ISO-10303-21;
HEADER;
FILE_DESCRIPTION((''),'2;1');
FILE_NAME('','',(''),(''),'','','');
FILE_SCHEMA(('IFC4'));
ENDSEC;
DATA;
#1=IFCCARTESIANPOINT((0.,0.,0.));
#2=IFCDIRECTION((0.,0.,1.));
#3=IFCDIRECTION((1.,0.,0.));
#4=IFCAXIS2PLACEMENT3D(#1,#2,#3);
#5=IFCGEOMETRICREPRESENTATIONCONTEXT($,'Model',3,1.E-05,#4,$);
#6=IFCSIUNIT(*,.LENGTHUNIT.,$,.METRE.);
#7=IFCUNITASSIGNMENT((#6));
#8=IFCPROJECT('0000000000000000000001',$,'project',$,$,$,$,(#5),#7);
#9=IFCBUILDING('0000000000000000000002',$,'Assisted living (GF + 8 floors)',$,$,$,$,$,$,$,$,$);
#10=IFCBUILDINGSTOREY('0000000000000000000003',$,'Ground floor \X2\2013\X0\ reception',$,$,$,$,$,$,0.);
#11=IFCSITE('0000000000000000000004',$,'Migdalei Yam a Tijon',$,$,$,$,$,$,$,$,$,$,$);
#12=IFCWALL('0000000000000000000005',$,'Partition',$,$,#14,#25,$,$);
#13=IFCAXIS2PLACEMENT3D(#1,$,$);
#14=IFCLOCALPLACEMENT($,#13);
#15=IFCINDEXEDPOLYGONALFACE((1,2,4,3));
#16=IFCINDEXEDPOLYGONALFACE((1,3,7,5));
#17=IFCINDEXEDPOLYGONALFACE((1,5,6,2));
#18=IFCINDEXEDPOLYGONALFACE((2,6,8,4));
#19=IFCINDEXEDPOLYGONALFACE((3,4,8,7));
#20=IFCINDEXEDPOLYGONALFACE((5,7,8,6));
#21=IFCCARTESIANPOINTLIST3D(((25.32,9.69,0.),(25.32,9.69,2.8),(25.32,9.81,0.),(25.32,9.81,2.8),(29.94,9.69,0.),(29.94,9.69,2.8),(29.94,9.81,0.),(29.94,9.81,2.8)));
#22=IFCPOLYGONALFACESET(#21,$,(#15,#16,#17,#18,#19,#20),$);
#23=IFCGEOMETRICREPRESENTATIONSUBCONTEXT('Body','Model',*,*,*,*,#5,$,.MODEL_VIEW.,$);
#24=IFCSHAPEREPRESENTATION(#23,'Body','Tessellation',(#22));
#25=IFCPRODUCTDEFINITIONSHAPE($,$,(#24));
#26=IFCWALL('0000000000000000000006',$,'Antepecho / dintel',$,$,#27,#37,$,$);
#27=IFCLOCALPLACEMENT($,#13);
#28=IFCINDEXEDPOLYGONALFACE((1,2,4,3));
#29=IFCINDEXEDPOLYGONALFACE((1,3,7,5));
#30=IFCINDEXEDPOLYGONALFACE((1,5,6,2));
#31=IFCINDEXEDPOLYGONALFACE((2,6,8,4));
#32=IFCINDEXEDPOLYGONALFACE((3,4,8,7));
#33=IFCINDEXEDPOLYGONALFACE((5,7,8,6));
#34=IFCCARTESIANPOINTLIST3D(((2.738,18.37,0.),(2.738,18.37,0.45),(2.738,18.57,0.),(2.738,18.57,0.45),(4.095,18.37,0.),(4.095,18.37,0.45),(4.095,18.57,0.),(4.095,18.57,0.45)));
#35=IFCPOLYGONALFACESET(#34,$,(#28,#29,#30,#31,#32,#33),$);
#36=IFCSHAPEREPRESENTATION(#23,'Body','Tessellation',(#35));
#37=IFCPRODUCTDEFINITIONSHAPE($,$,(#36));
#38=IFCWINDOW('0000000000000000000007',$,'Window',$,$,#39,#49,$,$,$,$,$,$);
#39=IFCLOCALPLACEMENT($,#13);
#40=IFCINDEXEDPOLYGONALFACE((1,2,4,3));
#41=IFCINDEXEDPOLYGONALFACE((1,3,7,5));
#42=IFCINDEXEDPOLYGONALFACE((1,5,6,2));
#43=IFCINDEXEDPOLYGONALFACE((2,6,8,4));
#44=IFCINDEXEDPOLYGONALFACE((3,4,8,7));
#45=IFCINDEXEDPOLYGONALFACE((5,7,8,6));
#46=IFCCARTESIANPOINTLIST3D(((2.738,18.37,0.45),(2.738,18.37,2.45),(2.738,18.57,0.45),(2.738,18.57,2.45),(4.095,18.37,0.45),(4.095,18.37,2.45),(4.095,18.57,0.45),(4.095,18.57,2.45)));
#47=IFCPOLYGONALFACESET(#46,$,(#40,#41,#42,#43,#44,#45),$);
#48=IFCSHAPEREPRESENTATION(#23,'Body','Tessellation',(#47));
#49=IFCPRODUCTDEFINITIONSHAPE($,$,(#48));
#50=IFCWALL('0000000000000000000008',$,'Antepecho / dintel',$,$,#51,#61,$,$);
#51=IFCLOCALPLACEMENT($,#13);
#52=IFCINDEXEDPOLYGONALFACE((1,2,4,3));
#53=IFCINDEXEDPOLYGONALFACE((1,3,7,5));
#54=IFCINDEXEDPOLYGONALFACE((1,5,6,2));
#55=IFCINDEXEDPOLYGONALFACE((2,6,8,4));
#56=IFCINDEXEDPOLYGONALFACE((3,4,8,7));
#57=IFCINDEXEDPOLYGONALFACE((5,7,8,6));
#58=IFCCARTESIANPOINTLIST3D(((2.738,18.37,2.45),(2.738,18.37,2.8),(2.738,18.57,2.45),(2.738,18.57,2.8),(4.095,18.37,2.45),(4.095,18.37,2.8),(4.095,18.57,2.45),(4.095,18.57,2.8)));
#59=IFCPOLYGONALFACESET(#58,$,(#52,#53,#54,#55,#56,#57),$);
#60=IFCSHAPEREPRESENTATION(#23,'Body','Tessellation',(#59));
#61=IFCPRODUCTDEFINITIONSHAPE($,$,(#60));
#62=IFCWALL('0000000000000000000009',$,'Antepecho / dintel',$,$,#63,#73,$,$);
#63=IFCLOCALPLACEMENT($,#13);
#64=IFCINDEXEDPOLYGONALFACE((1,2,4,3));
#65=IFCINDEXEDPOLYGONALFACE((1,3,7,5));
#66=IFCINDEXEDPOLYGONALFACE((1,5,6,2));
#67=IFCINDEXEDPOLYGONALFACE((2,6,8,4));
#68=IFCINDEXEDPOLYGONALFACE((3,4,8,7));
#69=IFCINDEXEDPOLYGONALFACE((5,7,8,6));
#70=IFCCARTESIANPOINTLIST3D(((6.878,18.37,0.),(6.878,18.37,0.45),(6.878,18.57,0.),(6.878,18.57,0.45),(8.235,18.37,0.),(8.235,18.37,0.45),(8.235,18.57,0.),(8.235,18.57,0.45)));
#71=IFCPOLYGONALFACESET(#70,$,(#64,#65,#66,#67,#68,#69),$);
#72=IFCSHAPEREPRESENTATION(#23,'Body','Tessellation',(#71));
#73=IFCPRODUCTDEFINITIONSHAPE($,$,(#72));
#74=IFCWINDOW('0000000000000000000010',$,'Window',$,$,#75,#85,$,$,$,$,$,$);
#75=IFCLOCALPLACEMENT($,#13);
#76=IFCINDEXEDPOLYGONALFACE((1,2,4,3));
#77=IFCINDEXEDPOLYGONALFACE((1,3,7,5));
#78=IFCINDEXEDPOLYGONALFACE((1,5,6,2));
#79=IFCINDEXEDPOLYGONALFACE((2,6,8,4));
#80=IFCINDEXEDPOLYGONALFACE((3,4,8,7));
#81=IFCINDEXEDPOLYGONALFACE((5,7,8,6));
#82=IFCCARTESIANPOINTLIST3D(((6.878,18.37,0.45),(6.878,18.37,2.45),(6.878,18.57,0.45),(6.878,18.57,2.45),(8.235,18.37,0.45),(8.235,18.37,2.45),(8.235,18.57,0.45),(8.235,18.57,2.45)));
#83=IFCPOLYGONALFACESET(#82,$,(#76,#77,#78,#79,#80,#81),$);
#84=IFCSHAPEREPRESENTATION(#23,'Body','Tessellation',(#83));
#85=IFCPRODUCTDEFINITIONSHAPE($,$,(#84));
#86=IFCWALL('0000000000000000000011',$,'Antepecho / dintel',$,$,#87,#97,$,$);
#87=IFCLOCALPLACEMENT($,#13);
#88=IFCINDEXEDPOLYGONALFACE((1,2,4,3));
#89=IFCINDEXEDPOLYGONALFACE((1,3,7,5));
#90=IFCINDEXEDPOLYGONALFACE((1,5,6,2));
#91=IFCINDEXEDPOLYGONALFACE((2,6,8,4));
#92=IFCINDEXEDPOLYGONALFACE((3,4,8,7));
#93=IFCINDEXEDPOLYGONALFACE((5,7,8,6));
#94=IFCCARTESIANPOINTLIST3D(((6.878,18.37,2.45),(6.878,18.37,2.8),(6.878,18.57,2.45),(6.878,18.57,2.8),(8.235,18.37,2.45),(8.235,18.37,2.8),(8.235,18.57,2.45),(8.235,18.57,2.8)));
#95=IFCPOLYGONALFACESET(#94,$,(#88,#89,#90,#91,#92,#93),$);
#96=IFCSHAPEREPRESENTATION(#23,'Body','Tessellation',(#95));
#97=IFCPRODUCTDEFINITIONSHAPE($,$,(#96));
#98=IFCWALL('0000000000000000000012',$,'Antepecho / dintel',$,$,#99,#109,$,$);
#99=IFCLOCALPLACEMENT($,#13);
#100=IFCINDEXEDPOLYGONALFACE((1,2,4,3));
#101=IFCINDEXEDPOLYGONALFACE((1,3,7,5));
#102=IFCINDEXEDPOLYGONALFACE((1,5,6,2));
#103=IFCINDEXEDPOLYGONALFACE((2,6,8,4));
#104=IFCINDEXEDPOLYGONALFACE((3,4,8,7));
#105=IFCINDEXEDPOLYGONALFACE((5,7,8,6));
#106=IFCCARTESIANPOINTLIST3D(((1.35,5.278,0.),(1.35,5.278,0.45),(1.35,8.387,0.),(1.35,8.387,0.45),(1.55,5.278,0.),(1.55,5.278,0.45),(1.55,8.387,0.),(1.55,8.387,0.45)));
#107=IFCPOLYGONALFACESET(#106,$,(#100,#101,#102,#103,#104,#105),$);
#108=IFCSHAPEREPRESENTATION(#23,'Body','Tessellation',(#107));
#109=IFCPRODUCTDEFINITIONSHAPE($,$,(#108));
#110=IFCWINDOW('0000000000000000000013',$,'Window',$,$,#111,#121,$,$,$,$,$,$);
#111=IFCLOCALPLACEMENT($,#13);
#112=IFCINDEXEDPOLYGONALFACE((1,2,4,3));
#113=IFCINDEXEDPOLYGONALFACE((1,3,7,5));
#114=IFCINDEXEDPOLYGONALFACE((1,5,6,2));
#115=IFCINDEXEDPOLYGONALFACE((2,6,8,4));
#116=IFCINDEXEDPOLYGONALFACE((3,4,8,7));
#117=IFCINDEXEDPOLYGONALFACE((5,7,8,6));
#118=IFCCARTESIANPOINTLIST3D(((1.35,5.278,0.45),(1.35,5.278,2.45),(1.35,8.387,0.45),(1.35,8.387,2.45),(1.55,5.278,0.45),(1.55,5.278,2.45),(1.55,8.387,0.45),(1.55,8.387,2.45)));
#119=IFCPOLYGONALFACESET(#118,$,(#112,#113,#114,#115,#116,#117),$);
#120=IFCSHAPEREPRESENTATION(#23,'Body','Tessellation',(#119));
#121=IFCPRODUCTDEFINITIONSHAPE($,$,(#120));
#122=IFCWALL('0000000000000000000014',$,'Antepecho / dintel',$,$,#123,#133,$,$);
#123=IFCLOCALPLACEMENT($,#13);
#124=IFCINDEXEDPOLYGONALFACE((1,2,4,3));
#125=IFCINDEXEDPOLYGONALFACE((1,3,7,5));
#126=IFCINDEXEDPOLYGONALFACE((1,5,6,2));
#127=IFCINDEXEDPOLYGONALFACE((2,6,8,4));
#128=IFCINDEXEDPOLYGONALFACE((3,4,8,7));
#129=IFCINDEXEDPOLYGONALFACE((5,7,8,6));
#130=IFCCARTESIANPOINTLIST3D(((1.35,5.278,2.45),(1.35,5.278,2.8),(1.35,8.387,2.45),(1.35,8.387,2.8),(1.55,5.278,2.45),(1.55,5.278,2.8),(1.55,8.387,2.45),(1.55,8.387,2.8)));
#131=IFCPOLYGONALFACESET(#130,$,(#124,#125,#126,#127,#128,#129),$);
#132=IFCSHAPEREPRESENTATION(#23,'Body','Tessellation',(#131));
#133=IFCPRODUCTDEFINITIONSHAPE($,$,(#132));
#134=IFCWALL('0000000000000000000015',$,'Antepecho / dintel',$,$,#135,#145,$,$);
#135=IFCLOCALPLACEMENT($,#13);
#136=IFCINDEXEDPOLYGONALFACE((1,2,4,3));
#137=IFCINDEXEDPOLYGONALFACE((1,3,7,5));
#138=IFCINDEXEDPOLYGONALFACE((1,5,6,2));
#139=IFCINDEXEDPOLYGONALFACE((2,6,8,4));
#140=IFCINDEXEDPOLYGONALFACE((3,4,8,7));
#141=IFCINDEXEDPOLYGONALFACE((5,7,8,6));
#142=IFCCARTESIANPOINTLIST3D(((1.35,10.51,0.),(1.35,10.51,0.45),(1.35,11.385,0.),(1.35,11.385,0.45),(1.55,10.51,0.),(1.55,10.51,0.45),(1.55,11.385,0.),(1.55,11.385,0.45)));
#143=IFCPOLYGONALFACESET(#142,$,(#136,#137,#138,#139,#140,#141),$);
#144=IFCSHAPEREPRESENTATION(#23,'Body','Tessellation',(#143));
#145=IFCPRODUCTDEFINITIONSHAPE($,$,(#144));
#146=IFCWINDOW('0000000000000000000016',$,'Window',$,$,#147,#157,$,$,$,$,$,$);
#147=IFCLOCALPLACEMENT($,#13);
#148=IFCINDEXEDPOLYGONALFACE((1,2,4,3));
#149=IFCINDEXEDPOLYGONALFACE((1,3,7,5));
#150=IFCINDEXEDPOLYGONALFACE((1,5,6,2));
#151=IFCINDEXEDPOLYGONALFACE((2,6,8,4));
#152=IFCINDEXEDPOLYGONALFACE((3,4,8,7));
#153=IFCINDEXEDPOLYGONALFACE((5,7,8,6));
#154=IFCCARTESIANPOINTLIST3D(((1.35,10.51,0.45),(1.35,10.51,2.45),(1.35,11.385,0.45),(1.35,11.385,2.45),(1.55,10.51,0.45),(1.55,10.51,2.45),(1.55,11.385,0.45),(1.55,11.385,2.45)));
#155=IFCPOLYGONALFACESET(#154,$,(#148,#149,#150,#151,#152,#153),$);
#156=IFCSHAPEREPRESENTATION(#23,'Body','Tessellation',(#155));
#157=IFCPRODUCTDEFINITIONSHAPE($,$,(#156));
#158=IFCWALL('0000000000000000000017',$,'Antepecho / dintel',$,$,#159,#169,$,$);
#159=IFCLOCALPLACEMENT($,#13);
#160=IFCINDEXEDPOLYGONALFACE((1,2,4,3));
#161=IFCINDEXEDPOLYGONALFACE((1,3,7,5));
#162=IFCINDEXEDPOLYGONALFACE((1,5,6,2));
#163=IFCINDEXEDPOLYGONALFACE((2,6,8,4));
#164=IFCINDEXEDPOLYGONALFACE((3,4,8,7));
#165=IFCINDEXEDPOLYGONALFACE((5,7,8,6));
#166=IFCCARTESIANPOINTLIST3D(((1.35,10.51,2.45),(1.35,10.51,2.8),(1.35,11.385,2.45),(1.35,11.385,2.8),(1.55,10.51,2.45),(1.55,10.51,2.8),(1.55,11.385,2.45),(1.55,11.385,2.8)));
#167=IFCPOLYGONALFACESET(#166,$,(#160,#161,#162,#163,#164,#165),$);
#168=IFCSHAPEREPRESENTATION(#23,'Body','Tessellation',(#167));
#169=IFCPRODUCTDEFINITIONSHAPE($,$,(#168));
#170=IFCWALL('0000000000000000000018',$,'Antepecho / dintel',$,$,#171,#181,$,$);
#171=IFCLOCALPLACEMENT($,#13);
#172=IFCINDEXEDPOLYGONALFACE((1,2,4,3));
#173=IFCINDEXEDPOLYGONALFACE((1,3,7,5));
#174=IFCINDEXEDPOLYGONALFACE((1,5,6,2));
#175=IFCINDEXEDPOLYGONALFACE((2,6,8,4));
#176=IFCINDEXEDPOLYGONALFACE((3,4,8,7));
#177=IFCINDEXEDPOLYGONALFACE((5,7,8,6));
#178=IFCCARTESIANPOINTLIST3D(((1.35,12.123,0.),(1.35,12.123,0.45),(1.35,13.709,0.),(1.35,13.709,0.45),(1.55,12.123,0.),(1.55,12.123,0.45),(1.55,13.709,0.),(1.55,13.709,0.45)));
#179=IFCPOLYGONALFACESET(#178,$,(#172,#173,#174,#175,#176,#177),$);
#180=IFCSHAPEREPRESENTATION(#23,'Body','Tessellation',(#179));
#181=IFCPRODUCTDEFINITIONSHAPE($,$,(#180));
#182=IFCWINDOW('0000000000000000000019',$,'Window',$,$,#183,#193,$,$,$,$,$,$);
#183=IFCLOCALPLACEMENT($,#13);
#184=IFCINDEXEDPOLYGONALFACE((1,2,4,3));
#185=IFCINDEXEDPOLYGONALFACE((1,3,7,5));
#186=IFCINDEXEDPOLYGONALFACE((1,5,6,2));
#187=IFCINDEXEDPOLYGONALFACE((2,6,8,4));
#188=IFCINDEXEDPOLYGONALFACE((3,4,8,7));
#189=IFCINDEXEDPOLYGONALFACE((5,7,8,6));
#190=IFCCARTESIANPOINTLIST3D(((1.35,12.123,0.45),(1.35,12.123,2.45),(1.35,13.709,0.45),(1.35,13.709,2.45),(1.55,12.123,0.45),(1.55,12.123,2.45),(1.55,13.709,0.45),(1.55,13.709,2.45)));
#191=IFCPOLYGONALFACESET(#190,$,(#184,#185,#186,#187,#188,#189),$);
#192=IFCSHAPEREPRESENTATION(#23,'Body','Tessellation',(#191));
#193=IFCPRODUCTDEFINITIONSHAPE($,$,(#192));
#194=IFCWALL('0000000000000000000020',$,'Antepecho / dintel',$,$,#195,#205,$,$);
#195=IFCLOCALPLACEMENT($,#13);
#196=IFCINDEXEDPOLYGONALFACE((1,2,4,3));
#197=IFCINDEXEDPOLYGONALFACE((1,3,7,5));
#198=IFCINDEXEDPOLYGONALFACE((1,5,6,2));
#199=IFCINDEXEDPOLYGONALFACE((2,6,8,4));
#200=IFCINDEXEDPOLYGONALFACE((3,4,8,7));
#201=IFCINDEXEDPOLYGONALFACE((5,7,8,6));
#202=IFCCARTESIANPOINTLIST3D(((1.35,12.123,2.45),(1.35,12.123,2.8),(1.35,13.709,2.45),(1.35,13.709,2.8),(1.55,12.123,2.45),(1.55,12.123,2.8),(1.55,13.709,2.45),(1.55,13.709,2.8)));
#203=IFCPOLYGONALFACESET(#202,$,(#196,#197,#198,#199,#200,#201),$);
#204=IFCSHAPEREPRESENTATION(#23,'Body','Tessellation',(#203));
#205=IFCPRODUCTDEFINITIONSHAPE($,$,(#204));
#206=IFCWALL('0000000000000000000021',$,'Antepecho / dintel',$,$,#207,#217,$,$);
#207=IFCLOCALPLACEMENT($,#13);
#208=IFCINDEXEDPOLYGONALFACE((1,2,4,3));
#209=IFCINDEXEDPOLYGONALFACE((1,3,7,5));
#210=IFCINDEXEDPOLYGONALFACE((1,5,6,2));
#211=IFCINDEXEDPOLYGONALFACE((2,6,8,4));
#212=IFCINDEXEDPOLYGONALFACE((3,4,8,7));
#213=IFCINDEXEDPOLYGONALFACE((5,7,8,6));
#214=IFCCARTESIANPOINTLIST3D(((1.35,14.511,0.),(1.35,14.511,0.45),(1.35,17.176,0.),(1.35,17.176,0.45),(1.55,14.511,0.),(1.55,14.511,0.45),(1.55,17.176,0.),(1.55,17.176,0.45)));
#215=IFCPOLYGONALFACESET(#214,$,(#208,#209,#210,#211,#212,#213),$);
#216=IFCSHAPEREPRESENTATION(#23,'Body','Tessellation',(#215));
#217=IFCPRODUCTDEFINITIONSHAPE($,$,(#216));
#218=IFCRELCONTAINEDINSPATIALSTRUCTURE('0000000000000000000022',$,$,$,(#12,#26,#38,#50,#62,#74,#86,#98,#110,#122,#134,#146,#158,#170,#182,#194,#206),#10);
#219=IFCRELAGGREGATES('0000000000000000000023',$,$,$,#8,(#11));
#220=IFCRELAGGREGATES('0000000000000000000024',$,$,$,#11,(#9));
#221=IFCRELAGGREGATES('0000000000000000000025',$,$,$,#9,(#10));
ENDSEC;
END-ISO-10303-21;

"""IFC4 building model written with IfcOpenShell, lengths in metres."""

from ifc_helpers import new_model, si_unit, frame, origin_with_axes, context, subcontext, project, spatial, line, indexed_curve, outline, extrude, element, save


model = new_model("IFC4")

# Units and contexts
model_context = context("Model", 3, precision=1e-05, world=origin_with_axes())
body_context = subcontext(model_context, "Body", "Model", "MODEL_VIEW")
ifc_project = project(units=[si_unit("LENGTHUNIT", "METRE")], contexts=[model_context])

# Site, building, storey
site = spatial("IfcSite", under=ifc_project, Name="Migdalei Yam a Tijon")
building = spatial("IfcBuilding", under=site, Name="Assisted living (GF + 8 floors)")
storey = spatial("IfcBuildingStorey", under=building, Name="Ground floor – reception", Elevation=0.0)

# Walls
element("IfcWall", 1, inside=storey, Name="Partition", context=body_context, shape_type="SweptSolid", body=[
    extrude(outline(indexed_curve([(0.0, 0.0), (4.62, 0.0), (4.62, 0.12), (0.0, 0.12)], segments=[line(1, 2, 3, 4, 1)])), frame((25.32, 9.69, 0.0), z_axis=(0.0, 0.0, 1.0), x_axis=(1.0, 0.0, 0.0)), (0.0, 0.0, 1.0), 2.8),
])
element("IfcWall", 2, inside=storey, Name="Antepecho / dintel", context=body_context, shape_type="SweptSolid", body=[
    extrude(outline(indexed_curve([(0.0, 0.0), (1.357, 0.0), (1.357, 0.2), (0.0, 0.2)], segments=[line(1, 2, 3, 4, 1)])), frame((2.738, 18.37, 0.0), z_axis=(0.0, 0.0, 1.0), x_axis=(1.0, 0.0, 0.0)), (0.0, 0.0, 1.0), 0.45),
])

# Window
element("IfcWindow", 3, inside=storey, Name="Window", context=body_context, shape_type="SweptSolid", body=[
    extrude(outline(indexed_curve([(0.0, 0.0), (1.357, 0.0), (1.357, 0.2), (0.0, 0.2)], segments=[line(1, 2, 3, 4, 1)])), frame((2.738, 18.37, 0.45), z_axis=(0.0, 0.0, 1.0), x_axis=(1.0, 0.0, 0.0)), (0.0, 0.0, 1.0), 2.0),
])

# Walls
element("IfcWall", 4, inside=storey, Name="Antepecho / dintel", context=body_context, shape_type="SweptSolid", body=[
    extrude(outline(indexed_curve([(0.0, 0.0), (1.357, 0.0), (1.357, 0.2), (0.0, 0.2)], segments=[line(1, 2, 3, 4, 1)])), frame((2.738, 18.37, 2.45), z_axis=(0.0, 0.0, 1.0), x_axis=(1.0, 0.0, 0.0)), (0.0, 0.0, 1.0), 0.35),
])
element("IfcWall", 5, inside=storey, Name="Antepecho / dintel", context=body_context, shape_type="SweptSolid", body=[
    extrude(outline(indexed_curve([(0.0, 0.0), (1.357, 0.0), (1.357, 0.2), (0.0, 0.2)], segments=[line(1, 2, 3, 4, 1)])), frame((6.878, 18.37, 0.0), z_axis=(0.0, 0.0, 1.0), x_axis=(1.0, 0.0, 0.0)), (0.0, 0.0, 1.0), 0.45),
])

# Window
element("IfcWindow", 6, inside=storey, Name="Window", context=body_context, shape_type="SweptSolid", body=[
    extrude(outline(indexed_curve([(0.0, 0.0), (1.357, 0.0), (1.357, 0.2), (0.0, 0.2)], segments=[line(1, 2, 3, 4, 1)])), frame((6.878, 18.37, 0.45), z_axis=(0.0, 0.0, 1.0), x_axis=(1.0, 0.0, 0.0)), (0.0, 0.0, 1.0), 2.0),
])

# Walls
element("IfcWall", 7, inside=storey, Name="Antepecho / dintel", context=body_context, shape_type="SweptSolid", body=[
    extrude(outline(indexed_curve([(0.0, 0.0), (1.357, 0.0), (1.357, 0.2), (0.0, 0.2)], segments=[line(1, 2, 3, 4, 1)])), frame((6.878, 18.37, 2.45), z_axis=(0.0, 0.0, 1.0), x_axis=(1.0, 0.0, 0.0)), (0.0, 0.0, 1.0), 0.35),
])
element("IfcWall", 8, inside=storey, Name="Antepecho / dintel", context=body_context, shape_type="SweptSolid", body=[
    extrude(outline(indexed_curve([(0.0, 0.0), (0.2, 0.0), (0.2, 3.109), (0.0, 3.109)], segments=[line(1, 2, 3, 4, 1)])), frame((1.35, 5.278, 0.0), z_axis=(0.0, 0.0, 1.0), x_axis=(1.0, 0.0, 0.0)), (0.0, 0.0, 1.0), 0.45),
])

# Window
element("IfcWindow", 9, inside=storey, Name="Window", context=body_context, shape_type="SweptSolid", body=[
    extrude(outline(indexed_curve([(0.0, 0.0), (0.2, 0.0), (0.2, 3.109), (0.0, 3.109)], segments=[line(1, 2, 3, 4, 1)])), frame((1.35, 5.278, 0.45), z_axis=(0.0, 0.0, 1.0), x_axis=(1.0, 0.0, 0.0)), (0.0, 0.0, 1.0), 2.0),
])

# Walls
element("IfcWall", 10, inside=storey, Name="Antepecho / dintel", context=body_context, shape_type="SweptSolid", body=[
    extrude(outline(indexed_curve([(0.0, 0.0), (0.2, 0.0), (0.2, 3.109), (0.0, 3.109)], segments=[line(1, 2, 3, 4, 1)])), frame((1.35, 5.278, 2.45), z_axis=(0.0, 0.0, 1.0), x_axis=(1.0, 0.0, 0.0)), (0.0, 0.0, 1.0), 0.35),
])
element("IfcWall", 11, inside=storey, Name="Antepecho / dintel", context=body_context, shape_type="SweptSolid", body=[
    extrude(outline(indexed_curve([(0.0, 0.0), (0.2, 0.0), (0.2, 0.875), (0.0, 0.875)], segments=[line(1, 2, 3, 4, 1)])), frame((1.35, 10.51, 0.0), z_axis=(0.0, 0.0, 1.0), x_axis=(1.0, 0.0, 0.0)), (0.0, 0.0, 1.0), 0.45),
])

# Window
element("IfcWindow", 12, inside=storey, Name="Window", context=body_context, shape_type="SweptSolid", body=[
    extrude(outline(indexed_curve([(0.0, 0.0), (0.2, 0.0), (0.2, 0.875), (0.0, 0.875)], segments=[line(1, 2, 3, 4, 1)])), frame((1.35, 10.51, 0.45), z_axis=(0.0, 0.0, 1.0), x_axis=(1.0, 0.0, 0.0)), (0.0, 0.0, 1.0), 2.0),
])

# Walls
element("IfcWall", 13, inside=storey, Name="Antepecho / dintel", context=body_context, shape_type="SweptSolid", body=[
    extrude(outline(indexed_curve([(0.0, 0.0), (0.2, 0.0), (0.2, 0.875), (0.0, 0.875)], segments=[line(1, 2, 3, 4, 1)])), frame((1.35, 10.51, 2.45), z_axis=(0.0, 0.0, 1.0), x_axis=(1.0, 0.0, 0.0)), (0.0, 0.0, 1.0), 0.35),
])
element("IfcWall", 14, inside=storey, Name="Antepecho / dintel", context=body_context, shape_type="SweptSolid", body=[
    extrude(outline(indexed_curve([(0.0, 0.0), (0.2, 0.0), (0.2, 1.586), (0.0, 1.586)], segments=[line(1, 2, 3, 4, 1)])), frame((1.35, 12.123, 0.0), z_axis=(0.0, 0.0, 1.0), x_axis=(1.0, 0.0, 0.0)), (0.0, 0.0, 1.0), 0.45),
])

# Window
element("IfcWindow", 15, inside=storey, Name="Window", context=body_context, shape_type="SweptSolid", body=[
    extrude(outline(indexed_curve([(0.0, 0.0), (0.2, 0.0), (0.2, 1.586), (0.0, 1.586)], segments=[line(1, 2, 3, 4, 1)])), frame((1.35, 12.123, 0.45), z_axis=(0.0, 0.0, 1.0), x_axis=(1.0, 0.0, 0.0)), (0.0, 0.0, 1.0), 2.0),
])

# Walls
element("IfcWall", 16, inside=storey, Name="Antepecho / dintel", context=body_context, shape_type="SweptSolid", body=[
    extrude(outline(indexed_curve([(0.0, 0.0), (0.2, 0.0), (0.2, 1.586), (0.0, 1.586)], segments=[line(1, 2, 3, 4, 1)])), frame((1.35, 12.123, 2.45), z_axis=(0.0, 0.0, 1.0), x_axis=(1.0, 0.0, 0.0)), (0.0, 0.0, 1.0), 0.35),
])
element("IfcWall", 17, inside=storey, Name="Antepecho / dintel", context=body_context, shape_type="SweptSolid", body=[
    extrude(outline(indexed_curve([(0.0, 0.0), (0.2, 0.0), (0.2, 2.665), (0.0, 2.665)], segments=[line(1, 2, 3, 4, 1)])), frame((1.35, 14.511, 0.0), z_axis=(0.0, 0.0, 1.0), x_axis=(1.0, 0.0, 0.0)), (0.0, 0.0, 1.0), 0.45),
])

save(model, "model.ifc")
